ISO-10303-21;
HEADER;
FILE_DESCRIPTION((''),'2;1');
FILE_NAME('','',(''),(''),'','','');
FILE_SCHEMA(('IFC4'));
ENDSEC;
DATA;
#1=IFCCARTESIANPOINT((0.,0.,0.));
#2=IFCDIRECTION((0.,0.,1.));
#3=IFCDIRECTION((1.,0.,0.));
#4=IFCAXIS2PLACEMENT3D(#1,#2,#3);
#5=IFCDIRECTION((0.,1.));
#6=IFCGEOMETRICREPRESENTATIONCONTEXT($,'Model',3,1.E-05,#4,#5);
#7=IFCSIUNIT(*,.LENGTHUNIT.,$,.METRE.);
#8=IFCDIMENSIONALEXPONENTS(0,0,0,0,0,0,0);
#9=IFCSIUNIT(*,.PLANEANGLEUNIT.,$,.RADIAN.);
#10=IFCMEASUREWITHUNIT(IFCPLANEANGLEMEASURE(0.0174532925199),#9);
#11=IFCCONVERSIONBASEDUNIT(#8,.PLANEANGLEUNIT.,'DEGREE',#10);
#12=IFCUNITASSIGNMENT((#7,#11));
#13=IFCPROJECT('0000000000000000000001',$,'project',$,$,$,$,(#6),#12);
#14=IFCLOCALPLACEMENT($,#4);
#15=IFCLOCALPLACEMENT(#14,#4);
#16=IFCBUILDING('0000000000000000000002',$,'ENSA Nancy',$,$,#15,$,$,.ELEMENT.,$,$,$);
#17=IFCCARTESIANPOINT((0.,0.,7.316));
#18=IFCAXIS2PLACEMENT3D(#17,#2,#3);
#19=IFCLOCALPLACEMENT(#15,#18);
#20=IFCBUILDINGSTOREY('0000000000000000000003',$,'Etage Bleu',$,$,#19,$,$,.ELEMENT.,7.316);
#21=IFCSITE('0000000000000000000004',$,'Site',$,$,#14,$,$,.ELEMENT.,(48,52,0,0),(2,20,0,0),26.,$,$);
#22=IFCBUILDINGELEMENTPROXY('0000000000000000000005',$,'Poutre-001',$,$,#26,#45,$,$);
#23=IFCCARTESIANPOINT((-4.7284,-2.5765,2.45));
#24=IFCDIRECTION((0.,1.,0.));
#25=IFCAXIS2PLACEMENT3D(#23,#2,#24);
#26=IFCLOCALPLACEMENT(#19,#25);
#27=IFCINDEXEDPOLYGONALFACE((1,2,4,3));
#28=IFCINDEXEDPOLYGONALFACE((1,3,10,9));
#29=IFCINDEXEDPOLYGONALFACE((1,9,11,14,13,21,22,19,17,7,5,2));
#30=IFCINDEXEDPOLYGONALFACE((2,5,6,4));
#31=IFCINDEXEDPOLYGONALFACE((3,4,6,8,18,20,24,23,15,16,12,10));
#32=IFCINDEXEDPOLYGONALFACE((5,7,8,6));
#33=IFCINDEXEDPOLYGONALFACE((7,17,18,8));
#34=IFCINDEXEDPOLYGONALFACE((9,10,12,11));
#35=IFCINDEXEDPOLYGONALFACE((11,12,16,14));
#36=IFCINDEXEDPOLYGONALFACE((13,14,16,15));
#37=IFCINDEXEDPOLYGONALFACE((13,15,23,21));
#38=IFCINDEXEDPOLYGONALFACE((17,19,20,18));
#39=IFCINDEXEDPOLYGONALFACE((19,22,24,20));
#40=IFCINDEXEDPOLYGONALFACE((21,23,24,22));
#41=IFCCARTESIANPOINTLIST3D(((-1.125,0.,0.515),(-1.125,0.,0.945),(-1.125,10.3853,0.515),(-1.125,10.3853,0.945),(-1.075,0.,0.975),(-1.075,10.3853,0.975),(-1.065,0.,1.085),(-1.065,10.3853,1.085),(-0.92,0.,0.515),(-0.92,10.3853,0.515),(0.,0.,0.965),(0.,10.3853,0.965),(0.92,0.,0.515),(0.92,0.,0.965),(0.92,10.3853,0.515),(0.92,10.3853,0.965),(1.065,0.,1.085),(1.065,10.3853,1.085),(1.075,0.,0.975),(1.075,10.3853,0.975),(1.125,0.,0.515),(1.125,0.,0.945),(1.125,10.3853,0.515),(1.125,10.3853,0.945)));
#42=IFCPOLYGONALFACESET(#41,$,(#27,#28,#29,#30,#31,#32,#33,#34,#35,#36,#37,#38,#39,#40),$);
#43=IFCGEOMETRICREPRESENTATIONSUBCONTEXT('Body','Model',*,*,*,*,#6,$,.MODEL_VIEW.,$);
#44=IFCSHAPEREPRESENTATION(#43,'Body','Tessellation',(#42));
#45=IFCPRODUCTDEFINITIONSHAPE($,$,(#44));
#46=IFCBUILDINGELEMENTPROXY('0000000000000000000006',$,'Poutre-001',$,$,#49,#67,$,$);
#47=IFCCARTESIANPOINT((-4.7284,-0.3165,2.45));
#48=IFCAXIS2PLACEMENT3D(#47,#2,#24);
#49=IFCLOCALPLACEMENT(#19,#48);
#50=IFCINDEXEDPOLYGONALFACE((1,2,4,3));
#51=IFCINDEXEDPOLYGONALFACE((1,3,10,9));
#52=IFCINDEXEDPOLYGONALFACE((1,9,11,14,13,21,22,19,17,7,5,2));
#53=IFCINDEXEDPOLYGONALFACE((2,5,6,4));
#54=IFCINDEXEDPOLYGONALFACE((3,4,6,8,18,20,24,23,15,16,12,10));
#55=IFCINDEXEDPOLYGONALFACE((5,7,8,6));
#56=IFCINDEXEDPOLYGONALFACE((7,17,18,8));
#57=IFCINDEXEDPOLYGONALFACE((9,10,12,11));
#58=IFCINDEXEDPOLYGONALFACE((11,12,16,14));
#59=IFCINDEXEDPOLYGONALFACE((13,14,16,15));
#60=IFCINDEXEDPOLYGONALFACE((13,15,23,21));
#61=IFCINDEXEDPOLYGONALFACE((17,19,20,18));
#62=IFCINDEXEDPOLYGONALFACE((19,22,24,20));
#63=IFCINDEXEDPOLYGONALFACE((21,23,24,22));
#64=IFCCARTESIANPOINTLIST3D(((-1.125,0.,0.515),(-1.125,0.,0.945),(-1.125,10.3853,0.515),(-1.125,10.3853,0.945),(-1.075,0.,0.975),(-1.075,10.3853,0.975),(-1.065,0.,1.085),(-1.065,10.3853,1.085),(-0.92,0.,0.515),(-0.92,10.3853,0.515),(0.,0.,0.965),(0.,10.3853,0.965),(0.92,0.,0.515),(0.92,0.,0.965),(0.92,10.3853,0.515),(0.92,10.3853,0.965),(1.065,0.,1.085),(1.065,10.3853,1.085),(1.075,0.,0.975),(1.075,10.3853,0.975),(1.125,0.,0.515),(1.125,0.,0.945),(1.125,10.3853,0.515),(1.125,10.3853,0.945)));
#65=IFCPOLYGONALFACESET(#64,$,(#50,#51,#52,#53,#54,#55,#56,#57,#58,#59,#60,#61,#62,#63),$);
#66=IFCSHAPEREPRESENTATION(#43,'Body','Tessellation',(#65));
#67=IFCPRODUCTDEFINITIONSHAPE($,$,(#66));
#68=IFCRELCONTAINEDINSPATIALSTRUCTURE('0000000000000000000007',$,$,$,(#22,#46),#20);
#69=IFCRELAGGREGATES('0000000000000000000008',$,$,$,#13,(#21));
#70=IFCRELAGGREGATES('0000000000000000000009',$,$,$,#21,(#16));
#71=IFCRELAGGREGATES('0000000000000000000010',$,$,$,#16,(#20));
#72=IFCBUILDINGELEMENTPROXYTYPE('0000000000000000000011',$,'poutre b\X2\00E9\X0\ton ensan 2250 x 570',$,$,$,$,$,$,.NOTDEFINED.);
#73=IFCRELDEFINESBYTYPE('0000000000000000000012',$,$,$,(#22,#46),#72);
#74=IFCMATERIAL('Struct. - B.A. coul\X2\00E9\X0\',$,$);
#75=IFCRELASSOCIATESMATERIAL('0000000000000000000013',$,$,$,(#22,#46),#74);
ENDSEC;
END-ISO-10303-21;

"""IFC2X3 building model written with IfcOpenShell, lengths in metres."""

from ifc_helpers import new_model, entity, si_unit, converted_unit, direction, frame, origin_with_axes, place, context, subcontext, project, spatial, polyline, outline, extrude, material, type_object, element, save


model = new_model("IFC2X3")

# Units and contexts
model_context = context("Model", 3, precision=1e-05, world=origin_with_axes(), true_north=direction((0.0, 1.0)))
body_context = subcontext(model_context, "Body", "Model", "MODEL_VIEW")
ifc_project = project(units=[si_unit("LENGTHUNIT", "METRE"), converted_unit("PLANEANGLEUNIT", "DEGREE", entity("IfcPlaneAngleMeasure", 0.0174532925199), si_unit("PLANEANGLEUNIT", "RADIAN"), dimensions=[0, 0, 0, 0, 0, 0, 0])], contexts=[model_context])

# Site, building, storey
site_placement = place(None, origin_with_axes())
site = spatial("IfcSite", under=ifc_project, at=site_placement, Name="Site", CompositionType="ELEMENT", RefLatitude=(48, 52, 0, 0), RefLongitude=(2, 20, 0, 0), RefElevation=26.0)
building_placement = place(site_placement, origin_with_axes())
building = spatial("IfcBuilding", under=site, at=building_placement, Name="ENSA Nancy", CompositionType="ELEMENT")
storey_placement = place(building_placement, frame((0.0, 0.0, 7.316), z_axis=(0.0, 0.0, 1.0), x_axis=(1.0, 0.0, 0.0)))
storey = spatial("IfcBuildingStorey", under=building, at=storey_placement, Name="Etage Bleu", CompositionType="ELEMENT", Elevation=7.316)

# Building element proxies
ifc_material_1 = material(Name="Struct. - B.A. coulé")
building_element_proxy_type_1 = type_object("IfcBuildingElementProxyType", Name="poutre béton ensan 2250 x 570", PredefinedType="NOTDEFINED")
for number, where, z_axis, x_axis, name in (
    (1, (-4.7284, -2.5765, 2.45), (0.0, 0.0, 1.0), (0.0, 1.0, 0.0), "Poutre-001"),
    (2, (-4.7284, -0.3165, 2.45), (0.0, 0.0, 1.0), (0.0, 1.0, 0.0), "Poutre-001"),
):
    element("IfcBuildingElementProxy", number, at=place(storey_placement, frame(where, z_axis=z_axis, x_axis=x_axis)), inside=storey, type_object=building_element_proxy_type_1, material=ifc_material_1, Name=name, context=body_context, shape_type="SweptSolid", body=[
        extrude(outline(polyline([(-1.065, 1.085), (-1.075, 0.975), (-1.125, 0.945), (-1.125, 0.515), (-0.92, 0.515), (0.0, 0.965), (0.92, 0.965), (0.92, 0.515), (1.125, 0.515), (1.125, 0.945), (1.075, 0.975), (1.065, 1.085), (-1.065, 1.085)])), frame((0.0, 10.3853, 0.0), z_axis=(0.0, -1.0, 0.0), x_axis=(1.0, 0.0, 0.0)), (0.0, 0.0, 1.0), 10.3853),
    ])

save(model, "model.ifc")
